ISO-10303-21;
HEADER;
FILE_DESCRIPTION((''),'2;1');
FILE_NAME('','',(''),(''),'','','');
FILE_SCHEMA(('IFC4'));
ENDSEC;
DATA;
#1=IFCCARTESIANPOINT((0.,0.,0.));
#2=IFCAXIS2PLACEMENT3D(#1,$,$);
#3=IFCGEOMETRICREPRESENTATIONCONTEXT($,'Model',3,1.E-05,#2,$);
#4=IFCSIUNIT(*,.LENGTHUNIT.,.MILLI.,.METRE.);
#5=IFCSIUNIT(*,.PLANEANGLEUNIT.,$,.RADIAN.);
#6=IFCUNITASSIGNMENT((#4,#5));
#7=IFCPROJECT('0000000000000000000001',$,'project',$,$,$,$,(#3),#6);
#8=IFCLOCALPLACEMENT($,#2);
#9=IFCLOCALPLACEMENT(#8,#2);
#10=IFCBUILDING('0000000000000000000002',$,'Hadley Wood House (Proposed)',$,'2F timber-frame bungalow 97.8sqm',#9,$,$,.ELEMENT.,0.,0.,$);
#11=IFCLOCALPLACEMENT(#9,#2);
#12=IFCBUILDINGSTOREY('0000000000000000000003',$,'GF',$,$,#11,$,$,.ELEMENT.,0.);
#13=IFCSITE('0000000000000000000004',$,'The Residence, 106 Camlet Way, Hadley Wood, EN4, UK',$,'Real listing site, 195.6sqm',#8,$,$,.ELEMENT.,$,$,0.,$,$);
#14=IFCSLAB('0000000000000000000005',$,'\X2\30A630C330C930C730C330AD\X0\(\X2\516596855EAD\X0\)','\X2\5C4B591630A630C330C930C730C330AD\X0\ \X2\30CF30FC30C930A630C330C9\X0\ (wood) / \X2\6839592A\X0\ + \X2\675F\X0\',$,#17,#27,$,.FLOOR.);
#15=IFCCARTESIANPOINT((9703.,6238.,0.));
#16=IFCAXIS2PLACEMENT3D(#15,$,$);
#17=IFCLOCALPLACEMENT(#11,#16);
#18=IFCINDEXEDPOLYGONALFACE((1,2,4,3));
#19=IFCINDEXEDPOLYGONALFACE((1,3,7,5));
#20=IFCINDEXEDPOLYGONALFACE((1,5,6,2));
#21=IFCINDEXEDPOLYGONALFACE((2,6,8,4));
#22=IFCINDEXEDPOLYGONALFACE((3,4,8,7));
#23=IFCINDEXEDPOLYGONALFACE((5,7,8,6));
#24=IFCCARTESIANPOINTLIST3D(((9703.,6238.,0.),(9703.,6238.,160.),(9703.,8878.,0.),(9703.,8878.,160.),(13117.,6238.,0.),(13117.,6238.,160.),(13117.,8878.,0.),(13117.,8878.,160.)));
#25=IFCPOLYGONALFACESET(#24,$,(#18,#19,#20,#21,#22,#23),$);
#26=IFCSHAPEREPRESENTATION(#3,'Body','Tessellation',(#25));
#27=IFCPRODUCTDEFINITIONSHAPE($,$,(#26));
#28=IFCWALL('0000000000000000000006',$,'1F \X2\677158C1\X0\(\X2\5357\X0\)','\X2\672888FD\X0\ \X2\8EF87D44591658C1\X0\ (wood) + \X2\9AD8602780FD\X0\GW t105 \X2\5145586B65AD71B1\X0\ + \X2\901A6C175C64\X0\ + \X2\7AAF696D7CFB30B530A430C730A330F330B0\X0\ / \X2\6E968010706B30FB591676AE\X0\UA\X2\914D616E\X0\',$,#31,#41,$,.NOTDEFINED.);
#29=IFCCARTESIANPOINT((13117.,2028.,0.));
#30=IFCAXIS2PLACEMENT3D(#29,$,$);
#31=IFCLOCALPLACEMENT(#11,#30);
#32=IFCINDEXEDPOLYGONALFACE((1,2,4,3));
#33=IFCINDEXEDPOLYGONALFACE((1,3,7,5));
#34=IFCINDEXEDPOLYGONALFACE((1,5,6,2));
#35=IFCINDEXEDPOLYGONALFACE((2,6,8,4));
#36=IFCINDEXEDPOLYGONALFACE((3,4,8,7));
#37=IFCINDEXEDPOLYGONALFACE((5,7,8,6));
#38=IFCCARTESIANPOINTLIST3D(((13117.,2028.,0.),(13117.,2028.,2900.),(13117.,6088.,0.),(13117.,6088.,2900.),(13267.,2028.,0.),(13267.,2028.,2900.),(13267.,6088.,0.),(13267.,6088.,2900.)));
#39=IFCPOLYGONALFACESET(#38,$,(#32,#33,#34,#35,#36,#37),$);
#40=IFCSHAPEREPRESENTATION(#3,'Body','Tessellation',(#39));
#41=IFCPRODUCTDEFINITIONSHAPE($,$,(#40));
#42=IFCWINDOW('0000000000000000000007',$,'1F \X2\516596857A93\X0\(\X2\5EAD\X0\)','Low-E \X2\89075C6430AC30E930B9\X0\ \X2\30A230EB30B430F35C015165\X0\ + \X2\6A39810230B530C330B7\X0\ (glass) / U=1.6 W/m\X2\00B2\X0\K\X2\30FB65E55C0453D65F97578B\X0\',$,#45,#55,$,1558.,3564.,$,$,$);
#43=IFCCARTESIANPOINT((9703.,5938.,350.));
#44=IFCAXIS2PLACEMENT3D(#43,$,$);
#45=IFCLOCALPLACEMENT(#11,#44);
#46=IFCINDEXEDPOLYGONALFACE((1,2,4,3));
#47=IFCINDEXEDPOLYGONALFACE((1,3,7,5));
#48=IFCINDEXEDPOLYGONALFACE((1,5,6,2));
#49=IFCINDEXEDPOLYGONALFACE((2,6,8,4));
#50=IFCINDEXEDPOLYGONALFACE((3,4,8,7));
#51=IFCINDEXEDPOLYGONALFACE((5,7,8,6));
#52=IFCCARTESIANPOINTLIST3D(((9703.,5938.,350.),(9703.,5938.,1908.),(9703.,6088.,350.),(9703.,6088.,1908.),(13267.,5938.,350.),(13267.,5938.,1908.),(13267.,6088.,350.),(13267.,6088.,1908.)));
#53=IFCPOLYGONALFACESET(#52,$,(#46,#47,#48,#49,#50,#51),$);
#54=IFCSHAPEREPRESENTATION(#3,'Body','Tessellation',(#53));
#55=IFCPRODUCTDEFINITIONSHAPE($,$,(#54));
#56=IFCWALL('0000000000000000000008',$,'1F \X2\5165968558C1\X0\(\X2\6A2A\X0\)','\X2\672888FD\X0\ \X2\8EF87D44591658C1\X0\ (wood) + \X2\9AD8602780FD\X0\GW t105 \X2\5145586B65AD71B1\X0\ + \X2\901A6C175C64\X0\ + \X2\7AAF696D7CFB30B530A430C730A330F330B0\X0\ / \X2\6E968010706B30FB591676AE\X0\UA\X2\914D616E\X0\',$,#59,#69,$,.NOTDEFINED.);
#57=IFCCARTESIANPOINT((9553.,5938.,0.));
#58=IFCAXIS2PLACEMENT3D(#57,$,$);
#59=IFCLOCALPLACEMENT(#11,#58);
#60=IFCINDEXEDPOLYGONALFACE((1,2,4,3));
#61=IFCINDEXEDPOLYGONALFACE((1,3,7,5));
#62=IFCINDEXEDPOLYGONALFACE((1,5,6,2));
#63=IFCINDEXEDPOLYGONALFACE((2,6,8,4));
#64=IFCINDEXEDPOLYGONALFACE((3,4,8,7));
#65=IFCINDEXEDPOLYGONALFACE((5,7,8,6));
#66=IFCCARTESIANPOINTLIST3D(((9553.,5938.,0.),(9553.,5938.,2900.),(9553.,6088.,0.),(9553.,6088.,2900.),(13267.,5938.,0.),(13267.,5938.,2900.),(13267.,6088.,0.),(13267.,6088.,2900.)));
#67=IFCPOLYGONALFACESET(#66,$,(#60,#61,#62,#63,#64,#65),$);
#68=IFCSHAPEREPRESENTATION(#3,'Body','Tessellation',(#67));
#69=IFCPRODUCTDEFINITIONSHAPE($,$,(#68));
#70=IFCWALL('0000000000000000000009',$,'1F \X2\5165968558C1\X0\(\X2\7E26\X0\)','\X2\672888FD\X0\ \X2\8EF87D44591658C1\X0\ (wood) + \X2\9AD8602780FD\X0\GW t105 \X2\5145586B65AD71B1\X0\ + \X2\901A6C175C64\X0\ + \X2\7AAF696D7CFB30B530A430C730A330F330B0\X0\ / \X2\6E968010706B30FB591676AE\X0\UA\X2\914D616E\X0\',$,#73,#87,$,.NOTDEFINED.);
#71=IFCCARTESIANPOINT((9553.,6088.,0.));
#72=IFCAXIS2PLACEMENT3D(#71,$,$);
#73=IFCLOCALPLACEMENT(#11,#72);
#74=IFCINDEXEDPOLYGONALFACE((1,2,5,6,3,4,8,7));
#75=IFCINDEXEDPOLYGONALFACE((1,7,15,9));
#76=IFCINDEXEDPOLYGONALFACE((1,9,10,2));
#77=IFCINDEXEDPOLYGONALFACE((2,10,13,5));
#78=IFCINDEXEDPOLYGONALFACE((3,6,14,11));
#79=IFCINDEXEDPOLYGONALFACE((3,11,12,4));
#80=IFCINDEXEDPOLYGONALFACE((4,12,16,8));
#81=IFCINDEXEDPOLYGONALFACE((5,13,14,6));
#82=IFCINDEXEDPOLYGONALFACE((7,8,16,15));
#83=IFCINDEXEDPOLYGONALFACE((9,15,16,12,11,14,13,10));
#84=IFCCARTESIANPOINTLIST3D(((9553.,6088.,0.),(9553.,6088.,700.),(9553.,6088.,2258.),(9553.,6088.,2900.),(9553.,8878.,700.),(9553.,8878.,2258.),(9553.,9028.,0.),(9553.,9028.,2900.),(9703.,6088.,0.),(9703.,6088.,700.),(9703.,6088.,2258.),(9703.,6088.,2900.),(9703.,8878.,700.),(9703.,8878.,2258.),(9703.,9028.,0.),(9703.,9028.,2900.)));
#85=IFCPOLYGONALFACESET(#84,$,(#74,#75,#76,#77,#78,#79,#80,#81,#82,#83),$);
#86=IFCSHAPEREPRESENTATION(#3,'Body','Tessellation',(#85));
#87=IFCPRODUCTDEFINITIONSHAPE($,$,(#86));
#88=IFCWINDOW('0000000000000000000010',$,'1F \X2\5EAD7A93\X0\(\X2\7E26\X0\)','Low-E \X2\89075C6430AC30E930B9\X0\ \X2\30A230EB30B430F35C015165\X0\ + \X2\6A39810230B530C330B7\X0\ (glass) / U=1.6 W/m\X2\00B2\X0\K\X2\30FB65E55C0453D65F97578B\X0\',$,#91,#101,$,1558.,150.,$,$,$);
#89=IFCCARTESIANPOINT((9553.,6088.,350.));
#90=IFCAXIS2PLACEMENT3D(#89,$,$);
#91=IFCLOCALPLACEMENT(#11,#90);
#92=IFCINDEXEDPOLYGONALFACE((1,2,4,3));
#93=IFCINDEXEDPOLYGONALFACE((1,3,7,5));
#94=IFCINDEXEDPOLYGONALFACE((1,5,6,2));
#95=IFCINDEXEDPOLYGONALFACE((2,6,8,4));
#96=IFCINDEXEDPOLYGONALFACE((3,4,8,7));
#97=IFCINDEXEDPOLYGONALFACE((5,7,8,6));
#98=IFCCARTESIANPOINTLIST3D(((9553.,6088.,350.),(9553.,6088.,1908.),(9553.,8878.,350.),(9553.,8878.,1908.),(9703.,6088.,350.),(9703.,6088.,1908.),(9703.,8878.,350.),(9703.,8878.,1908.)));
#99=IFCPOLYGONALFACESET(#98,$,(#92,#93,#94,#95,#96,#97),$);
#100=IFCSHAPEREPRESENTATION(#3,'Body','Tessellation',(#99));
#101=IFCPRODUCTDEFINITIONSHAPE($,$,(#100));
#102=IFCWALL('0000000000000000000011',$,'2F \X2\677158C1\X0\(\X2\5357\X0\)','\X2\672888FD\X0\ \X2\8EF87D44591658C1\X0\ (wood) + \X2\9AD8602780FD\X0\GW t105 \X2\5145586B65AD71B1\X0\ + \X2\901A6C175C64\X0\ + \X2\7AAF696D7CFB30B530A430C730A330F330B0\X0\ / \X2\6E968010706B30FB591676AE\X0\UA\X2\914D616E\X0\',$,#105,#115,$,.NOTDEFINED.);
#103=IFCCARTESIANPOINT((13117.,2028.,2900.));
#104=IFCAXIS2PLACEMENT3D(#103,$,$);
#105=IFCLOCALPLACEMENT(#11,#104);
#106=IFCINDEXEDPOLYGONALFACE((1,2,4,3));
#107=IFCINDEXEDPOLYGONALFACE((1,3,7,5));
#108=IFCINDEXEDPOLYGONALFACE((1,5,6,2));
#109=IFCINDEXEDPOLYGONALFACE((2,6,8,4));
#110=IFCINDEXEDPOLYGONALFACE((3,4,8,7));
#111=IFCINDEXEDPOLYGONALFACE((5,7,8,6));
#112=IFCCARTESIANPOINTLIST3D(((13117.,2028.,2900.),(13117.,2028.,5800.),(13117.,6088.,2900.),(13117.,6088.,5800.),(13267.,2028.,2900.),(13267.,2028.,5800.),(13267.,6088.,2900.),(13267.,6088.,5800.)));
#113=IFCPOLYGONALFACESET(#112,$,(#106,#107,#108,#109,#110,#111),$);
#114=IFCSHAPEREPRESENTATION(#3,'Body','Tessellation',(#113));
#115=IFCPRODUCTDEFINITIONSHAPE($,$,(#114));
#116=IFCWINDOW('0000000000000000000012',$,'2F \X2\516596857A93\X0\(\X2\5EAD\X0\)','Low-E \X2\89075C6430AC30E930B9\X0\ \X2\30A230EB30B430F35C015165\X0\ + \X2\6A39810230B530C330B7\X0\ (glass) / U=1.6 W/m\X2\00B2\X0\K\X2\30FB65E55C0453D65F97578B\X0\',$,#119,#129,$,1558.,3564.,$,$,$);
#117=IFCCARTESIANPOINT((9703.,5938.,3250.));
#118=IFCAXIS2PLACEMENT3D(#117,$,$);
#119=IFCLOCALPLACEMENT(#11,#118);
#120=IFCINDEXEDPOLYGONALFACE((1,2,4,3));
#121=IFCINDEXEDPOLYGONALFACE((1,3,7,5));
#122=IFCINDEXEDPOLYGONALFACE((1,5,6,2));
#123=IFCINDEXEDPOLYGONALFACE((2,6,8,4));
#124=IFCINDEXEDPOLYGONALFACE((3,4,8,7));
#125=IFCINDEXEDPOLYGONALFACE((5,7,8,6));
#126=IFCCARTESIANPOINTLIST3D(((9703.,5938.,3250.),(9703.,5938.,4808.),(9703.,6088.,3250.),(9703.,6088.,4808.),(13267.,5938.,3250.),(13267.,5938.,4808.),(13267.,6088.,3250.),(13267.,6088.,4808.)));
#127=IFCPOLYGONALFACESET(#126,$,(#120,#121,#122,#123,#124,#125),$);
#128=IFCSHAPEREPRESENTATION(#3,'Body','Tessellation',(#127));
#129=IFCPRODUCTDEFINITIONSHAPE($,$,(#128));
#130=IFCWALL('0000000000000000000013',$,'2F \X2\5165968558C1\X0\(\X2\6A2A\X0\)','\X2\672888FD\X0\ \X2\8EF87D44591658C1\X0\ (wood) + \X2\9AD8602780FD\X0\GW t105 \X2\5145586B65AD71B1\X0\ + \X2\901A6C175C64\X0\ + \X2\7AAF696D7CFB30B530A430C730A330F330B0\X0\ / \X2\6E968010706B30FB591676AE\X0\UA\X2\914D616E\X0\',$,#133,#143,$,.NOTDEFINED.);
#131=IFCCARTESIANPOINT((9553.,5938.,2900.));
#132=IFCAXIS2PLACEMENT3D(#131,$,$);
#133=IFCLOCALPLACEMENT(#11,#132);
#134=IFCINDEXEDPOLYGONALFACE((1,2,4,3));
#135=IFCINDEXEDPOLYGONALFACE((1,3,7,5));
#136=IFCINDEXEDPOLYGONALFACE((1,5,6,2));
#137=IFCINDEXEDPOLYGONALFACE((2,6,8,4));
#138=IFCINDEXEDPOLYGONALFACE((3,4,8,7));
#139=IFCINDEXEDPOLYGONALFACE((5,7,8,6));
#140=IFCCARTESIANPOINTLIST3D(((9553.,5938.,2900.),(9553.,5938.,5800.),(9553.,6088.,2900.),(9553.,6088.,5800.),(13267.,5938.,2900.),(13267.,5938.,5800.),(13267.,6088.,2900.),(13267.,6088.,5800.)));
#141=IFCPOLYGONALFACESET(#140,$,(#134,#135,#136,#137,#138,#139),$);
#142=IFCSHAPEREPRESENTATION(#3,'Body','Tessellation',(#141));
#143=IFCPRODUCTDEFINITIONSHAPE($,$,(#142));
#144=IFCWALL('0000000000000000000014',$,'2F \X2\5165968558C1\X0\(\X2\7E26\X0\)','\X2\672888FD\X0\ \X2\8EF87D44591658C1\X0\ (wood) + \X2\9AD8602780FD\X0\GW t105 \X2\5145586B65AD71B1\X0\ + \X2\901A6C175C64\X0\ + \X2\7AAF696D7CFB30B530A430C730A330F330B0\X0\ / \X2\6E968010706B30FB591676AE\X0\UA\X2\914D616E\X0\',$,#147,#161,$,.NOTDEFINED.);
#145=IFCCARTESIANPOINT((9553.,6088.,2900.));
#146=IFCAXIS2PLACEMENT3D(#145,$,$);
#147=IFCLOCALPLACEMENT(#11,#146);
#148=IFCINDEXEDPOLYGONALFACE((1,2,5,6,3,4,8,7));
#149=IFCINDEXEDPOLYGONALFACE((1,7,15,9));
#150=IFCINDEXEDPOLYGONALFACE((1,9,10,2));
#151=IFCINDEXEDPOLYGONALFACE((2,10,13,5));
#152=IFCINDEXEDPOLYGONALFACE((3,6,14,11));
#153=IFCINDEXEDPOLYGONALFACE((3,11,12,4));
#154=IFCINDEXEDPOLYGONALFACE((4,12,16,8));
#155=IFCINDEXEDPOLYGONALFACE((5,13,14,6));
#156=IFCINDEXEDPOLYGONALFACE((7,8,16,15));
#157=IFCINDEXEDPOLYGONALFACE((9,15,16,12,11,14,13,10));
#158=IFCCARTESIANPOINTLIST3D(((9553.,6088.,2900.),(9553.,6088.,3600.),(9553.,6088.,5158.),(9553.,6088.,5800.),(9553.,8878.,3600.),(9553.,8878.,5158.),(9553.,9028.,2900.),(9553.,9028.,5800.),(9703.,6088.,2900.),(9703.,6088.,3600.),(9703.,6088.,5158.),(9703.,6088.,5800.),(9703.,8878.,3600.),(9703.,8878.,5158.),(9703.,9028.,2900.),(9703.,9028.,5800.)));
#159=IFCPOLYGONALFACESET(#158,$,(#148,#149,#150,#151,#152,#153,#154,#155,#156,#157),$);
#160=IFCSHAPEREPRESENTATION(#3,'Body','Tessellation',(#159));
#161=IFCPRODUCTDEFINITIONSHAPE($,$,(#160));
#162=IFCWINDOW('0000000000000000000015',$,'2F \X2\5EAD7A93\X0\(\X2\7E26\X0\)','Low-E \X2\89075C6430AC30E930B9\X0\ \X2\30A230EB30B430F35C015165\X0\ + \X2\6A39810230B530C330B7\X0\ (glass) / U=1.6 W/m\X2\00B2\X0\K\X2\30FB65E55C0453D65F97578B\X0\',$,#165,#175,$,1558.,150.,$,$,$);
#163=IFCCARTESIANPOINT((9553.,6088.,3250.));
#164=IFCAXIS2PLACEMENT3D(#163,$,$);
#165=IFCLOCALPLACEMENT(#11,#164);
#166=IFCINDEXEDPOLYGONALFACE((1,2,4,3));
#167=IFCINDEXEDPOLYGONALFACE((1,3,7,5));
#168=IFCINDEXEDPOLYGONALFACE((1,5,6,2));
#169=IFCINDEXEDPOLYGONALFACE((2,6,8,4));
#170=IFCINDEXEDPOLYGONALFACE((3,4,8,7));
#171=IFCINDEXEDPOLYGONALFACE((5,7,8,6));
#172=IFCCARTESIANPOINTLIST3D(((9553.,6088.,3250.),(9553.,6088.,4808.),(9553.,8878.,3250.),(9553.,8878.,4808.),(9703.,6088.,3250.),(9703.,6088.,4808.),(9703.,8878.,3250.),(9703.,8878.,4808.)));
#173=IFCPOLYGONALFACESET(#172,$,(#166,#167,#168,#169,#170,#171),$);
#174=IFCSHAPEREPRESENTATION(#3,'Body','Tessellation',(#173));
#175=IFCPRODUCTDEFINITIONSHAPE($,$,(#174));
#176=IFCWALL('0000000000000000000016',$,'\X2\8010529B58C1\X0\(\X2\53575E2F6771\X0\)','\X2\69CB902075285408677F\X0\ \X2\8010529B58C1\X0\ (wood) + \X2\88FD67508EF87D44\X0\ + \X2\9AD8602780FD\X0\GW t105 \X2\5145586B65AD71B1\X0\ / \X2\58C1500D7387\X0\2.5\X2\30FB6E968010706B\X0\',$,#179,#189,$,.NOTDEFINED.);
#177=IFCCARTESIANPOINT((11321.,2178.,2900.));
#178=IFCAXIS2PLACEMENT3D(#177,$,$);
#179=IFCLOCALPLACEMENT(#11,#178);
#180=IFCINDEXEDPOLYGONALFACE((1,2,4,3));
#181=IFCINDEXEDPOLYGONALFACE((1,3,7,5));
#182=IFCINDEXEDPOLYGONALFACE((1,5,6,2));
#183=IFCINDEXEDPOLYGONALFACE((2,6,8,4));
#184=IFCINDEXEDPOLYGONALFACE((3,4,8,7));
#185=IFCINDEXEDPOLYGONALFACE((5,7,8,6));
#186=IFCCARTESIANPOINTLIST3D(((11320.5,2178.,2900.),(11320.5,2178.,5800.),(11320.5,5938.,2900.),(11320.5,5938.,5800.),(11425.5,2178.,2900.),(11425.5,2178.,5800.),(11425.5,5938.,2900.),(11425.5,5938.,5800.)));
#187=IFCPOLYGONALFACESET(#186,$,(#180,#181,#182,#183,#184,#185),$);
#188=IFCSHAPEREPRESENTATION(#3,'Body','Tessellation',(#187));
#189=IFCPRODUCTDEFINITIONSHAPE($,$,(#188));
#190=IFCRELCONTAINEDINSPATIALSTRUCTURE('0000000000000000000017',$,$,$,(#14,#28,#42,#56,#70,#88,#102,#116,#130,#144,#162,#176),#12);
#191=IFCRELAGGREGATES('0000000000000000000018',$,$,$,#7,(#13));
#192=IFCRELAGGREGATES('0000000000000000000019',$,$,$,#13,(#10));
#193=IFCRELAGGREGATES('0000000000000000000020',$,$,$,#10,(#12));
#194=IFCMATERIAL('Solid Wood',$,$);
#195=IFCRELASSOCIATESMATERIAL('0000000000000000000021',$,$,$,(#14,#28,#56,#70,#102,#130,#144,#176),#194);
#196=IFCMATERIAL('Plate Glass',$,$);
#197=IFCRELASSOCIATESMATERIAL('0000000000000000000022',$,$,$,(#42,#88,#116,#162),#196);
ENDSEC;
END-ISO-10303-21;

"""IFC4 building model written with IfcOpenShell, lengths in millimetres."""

from ifc_helpers import new_model, si_unit, frame, frame_2d, origin, place, context, project, spatial, rectangle, extrude, material, element, fill, save


model = new_model("IFC4")

# Units and contexts
model_context = context("Model", 3, precision=1e-05, world=origin())
ifc_project = project(units=[si_unit("LENGTHUNIT", "METRE", prefix="MILLI"), si_unit("PLANEANGLEUNIT", "RADIAN")], contexts=[model_context])

# Site, building, storey
site_placement = place(None, origin())
site = spatial("IfcSite", under=ifc_project, at=site_placement, Name="The Residence, 106 Camlet Way, Hadley Wood, EN4, UK", ObjectType="Real listing site, 195.6sqm", CompositionType="ELEMENT", RefElevation=0.0)
building_placement = place(site_placement, origin())
building = spatial("IfcBuilding", under=site, at=building_placement, Name="Hadley Wood House (Proposed)", ObjectType="2F timber-frame bungalow 97.8sqm", CompositionType="ELEMENT", ElevationOfRefHeight=0.0, ElevationOfTerrain=0.0)
storey_placement = place(building_placement, origin())
storey = spatial("IfcBuildingStorey", under=building, at=storey_placement, Name="GF", CompositionType="ELEMENT", Elevation=0.0)

# Slab
ifc_material_1 = material(Name="Solid Wood")
slab_placement = place(storey_placement, frame((9703.0, 6238.0, 0.0)))
element("IfcSlab", 1, at=slab_placement, inside=storey, material=ifc_material_1, Name="ウッドデッキ(入隅庭)", Description="屋外ウッドデッキ ハードウッド (wood) / 根太 + 束", PredefinedType="FLOOR", context=model_context, shape_type="SweptSolid", body=[
    extrude(rectangle(XDim=3414.0, YDim=2640.0, at=frame_2d((1707.0, 1320.0))), frame((9703.0, 6238.0, 0.0)), (0.0, 0.0, 1.0), 160.0),
])

# Wall, opening, window
wall_1_placement = place(storey_placement, frame((13117.0, 2028.0, 0.0)))
wall_1 = element("IfcWall", 2, at=wall_1_placement, inside=storey, material=ifc_material_1, Name="1F 東壁(南)", Description="木製 軸組外壁 (wood) + 高性能GW t105 充填断熱 + 通気層 + 窯業系サイディング / 準耐火・外皮UA配慮", PredefinedType="NOTDEFINED", context=model_context, shape_type="SweptSolid", body=[
    extrude(rectangle(XDim=150.0, YDim=4060.0, at=frame_2d((75.0, 2030.0))), frame((13117.0, 2028.0, 0.0)), (0.0, 0.0, 1.0), 2900.0),
])
opening_1_placement = place(storey_placement, frame((9703.0, 5938.0, 350.0)))
opening_1 = element("IfcOpeningElement", 3, at=opening_1_placement, cuts=wall_1, PredefinedType="NOTDEFINED", context=model_context, shape_type="SweptSolid", body=[
    extrude(rectangle(XDim=3564.0, YDim=150.0, at=frame_2d((1782.0, 75.0))), frame((9703.0, 5938.0, 350.0)), (0.0, 0.0, 1.0), 1558.0),
])
ifc_material_2 = material(Name="Plate Glass")
window_1_placement = place(storey_placement, frame((9703.0, 5938.0, 350.0)))
window_1 = element("IfcWindow", 4, at=window_1_placement, inside=storey, material=ifc_material_2, Name="1F 入隅窓(庭)", Description="Low-E 複層ガラス アルゴン封入 + 樹脂サッシ (glass) / U=1.6 W/m²K・日射取得型", OverallHeight=1558.0, OverallWidth=3564.0, context=model_context, shape_type="SweptSolid", body=[
    extrude(rectangle(XDim=3564.0, YDim=150.0, at=frame_2d((1782.0, 75.0))), frame((9703.0, 5938.0, 350.0)), (0.0, 0.0, 1.0), 1558.0),
])
fill(opening_1, window_1)

# Wall
wall_2_placement = place(storey_placement, frame((9553.0, 5938.0, 0.0)))
element("IfcWall", 5, at=wall_2_placement, inside=storey, material=ifc_material_1, Name="1F 入隅壁(横)", Description="木製 軸組外壁 (wood) + 高性能GW t105 充填断熱 + 通気層 + 窯業系サイディング / 準耐火・外皮UA配慮", PredefinedType="NOTDEFINED", context=model_context, shape_type="SweptSolid", body=[
    extrude(rectangle(XDim=3714.0, YDim=150.0, at=frame_2d((1857.0, 75.0))), frame((9553.0, 5938.0, 0.0)), (0.0, 0.0, 1.0), 2900.0),
])

# Wall, opening, window
wall_3_placement = place(storey_placement, frame((9553.0, 6088.0, 0.0)))
wall_3 = element("IfcWall", 6, at=wall_3_placement, inside=storey, material=ifc_material_1, Name="1F 入隅壁(縦)", Description="木製 軸組外壁 (wood) + 高性能GW t105 充填断熱 + 通気層 + 窯業系サイディング / 準耐火・外皮UA配慮", PredefinedType="NOTDEFINED", context=model_context, shape_type="SweptSolid", body=[
    extrude(rectangle(XDim=150.0, YDim=2940.0, at=frame_2d((75.0, 1470.0))), frame((9553.0, 6088.0, 0.0)), (0.0, 0.0, 1.0), 2900.0),
])
opening_2_placement = place(storey_placement, frame((9553.0, 6088.0, 350.0)))
opening_2 = element("IfcOpeningElement", 7, at=opening_2_placement, cuts=wall_3, PredefinedType="NOTDEFINED", context=model_context, shape_type="SweptSolid", body=[
    extrude(rectangle(XDim=150.0, YDim=2790.0, at=frame_2d((75.0, 1395.0))), frame((9553.0, 6088.0, 350.0)), (0.0, 0.0, 1.0), 1558.0),
])
window_2_placement = place(storey_placement, frame((9553.0, 6088.0, 350.0)))
window_2 = element("IfcWindow", 8, at=window_2_placement, inside=storey, material=ifc_material_2, Name="1F 庭窓(縦)", Description="Low-E 複層ガラス アルゴン封入 + 樹脂サッシ (glass) / U=1.6 W/m²K・日射取得型", OverallHeight=1558.0, OverallWidth=150.0, context=model_context, shape_type="SweptSolid", body=[
    extrude(rectangle(XDim=150.0, YDim=2790.0, at=frame_2d((75.0, 1395.0))), frame((9553.0, 6088.0, 350.0)), (0.0, 0.0, 1.0), 1558.0),
])
fill(opening_2, window_2)

# Wall, opening, window
wall_4_placement = place(storey_placement, frame((13117.0, 2028.0, 2900.0)))
wall_4 = element("IfcWall", 9, at=wall_4_placement, inside=storey, material=ifc_material_1, Name="2F 東壁(南)", Description="木製 軸組外壁 (wood) + 高性能GW t105 充填断熱 + 通気層 + 窯業系サイディング / 準耐火・外皮UA配慮", PredefinedType="NOTDEFINED", context=model_context, shape_type="SweptSolid", body=[
    extrude(rectangle(XDim=150.0, YDim=4060.0, at=frame_2d((75.0, 2030.0))), frame((13117.0, 2028.0, 2900.0)), (0.0, 0.0, 1.0), 2900.0),
])
opening_3_placement = place(storey_placement, frame((9703.0, 5938.0, 3250.0)))
opening_3 = element("IfcOpeningElement", 10, at=opening_3_placement, cuts=wall_4, PredefinedType="NOTDEFINED", context=model_context, shape_type="SweptSolid", body=[
    extrude(rectangle(XDim=3564.0, YDim=150.0, at=frame_2d((1782.0, 75.0))), frame((9703.0, 5938.0, 3250.0)), (0.0, 0.0, 1.0), 1558.0),
])
window_3_placement = place(storey_placement, frame((9703.0, 5938.0, 3250.0)))
window_3 = element("IfcWindow", 11, at=window_3_placement, inside=storey, material=ifc_material_2, Name="2F 入隅窓(庭)", Description="Low-E 複層ガラス アルゴン封入 + 樹脂サッシ (glass) / U=1.6 W/m²K・日射取得型", OverallHeight=1558.0, OverallWidth=3564.0, context=model_context, shape_type="SweptSolid", body=[
    extrude(rectangle(XDim=3564.0, YDim=150.0, at=frame_2d((1782.0, 75.0))), frame((9703.0, 5938.0, 3250.0)), (0.0, 0.0, 1.0), 1558.0),
])
fill(opening_3, window_3)

# Wall
wall_5_placement = place(storey_placement, frame((9553.0, 5938.0, 2900.0)))
element("IfcWall", 12, at=wall_5_placement, inside=storey, material=ifc_material_1, Name="2F 入隅壁(横)", Description="木製 軸組外壁 (wood) + 高性能GW t105 充填断熱 + 通気層 + 窯業系サイディング / 準耐火・外皮UA配慮", PredefinedType="NOTDEFINED", context=model_context, shape_type="SweptSolid", body=[
    extrude(rectangle(XDim=3714.0, YDim=150.0, at=frame_2d((1857.0, 75.0))), frame((9553.0, 5938.0, 2900.0)), (0.0, 0.0, 1.0), 2900.0),
])

# Wall, opening, window
wall_6_placement = place(storey_placement, frame((9553.0, 6088.0, 2900.0)))
wall_6 = element("IfcWall", 13, at=wall_6_placement, inside=storey, material=ifc_material_1, Name="2F 入隅壁(縦)", Description="木製 軸組外壁 (wood) + 高性能GW t105 充填断熱 + 通気層 + 窯業系サイディング / 準耐火・外皮UA配慮", PredefinedType="NOTDEFINED", context=model_context, shape_type="SweptSolid", body=[
    extrude(rectangle(XDim=150.0, YDim=2940.0, at=frame_2d((75.0, 1470.0))), frame((9553.0, 6088.0, 2900.0)), (0.0, 0.0, 1.0), 2900.0),
])
opening_4_placement = place(storey_placement, frame((9553.0, 6088.0, 3250.0)))
opening_4 = element("IfcOpeningElement", 14, at=opening_4_placement, cuts=wall_6, PredefinedType="NOTDEFINED", context=model_context, shape_type="SweptSolid", body=[
    extrude(rectangle(XDim=150.0, YDim=2790.0, at=frame_2d((75.0, 1395.0))), frame((9553.0, 6088.0, 3250.0)), (0.0, 0.0, 1.0), 1558.0),
])
window_4_placement = place(storey_placement, frame((9553.0, 6088.0, 3250.0)))
window_4 = element("IfcWindow", 15, at=window_4_placement, inside=storey, material=ifc_material_2, Name="2F 庭窓(縦)", Description="Low-E 複層ガラス アルゴン封入 + 樹脂サッシ (glass) / U=1.6 W/m²K・日射取得型", OverallHeight=1558.0, OverallWidth=150.0, context=model_context, shape_type="SweptSolid", body=[
    extrude(rectangle(XDim=150.0, YDim=2790.0, at=frame_2d((75.0, 1395.0))), frame((9553.0, 6088.0, 3250.0)), (0.0, 0.0, 1.0), 1558.0),
])
fill(opening_4, window_4)

# Wall
wall_7_placement = place(storey_placement, frame((11321.0, 2178.0, 2900.0)))
element("IfcWall", 16, at=wall_7_placement, inside=storey, material=ifc_material_1, Name="耐力壁(南帯東)", Description="構造用合板 耐力壁 (wood) + 製材軸組 + 高性能GW t105 充填断熱 / 壁倍率2.5・準耐火", PredefinedType="NOTDEFINED", context=model_context, shape_type="SweptSolid", body=[
    extrude(rectangle(XDim=105.0, YDim=3760.0, at=frame_2d((52.0, 1880.0))), frame((11321.0, 2178.0, 2900.0)), (0.0, 0.0, 1.0), 2900.0),
])

save(model, "model.ifc")
